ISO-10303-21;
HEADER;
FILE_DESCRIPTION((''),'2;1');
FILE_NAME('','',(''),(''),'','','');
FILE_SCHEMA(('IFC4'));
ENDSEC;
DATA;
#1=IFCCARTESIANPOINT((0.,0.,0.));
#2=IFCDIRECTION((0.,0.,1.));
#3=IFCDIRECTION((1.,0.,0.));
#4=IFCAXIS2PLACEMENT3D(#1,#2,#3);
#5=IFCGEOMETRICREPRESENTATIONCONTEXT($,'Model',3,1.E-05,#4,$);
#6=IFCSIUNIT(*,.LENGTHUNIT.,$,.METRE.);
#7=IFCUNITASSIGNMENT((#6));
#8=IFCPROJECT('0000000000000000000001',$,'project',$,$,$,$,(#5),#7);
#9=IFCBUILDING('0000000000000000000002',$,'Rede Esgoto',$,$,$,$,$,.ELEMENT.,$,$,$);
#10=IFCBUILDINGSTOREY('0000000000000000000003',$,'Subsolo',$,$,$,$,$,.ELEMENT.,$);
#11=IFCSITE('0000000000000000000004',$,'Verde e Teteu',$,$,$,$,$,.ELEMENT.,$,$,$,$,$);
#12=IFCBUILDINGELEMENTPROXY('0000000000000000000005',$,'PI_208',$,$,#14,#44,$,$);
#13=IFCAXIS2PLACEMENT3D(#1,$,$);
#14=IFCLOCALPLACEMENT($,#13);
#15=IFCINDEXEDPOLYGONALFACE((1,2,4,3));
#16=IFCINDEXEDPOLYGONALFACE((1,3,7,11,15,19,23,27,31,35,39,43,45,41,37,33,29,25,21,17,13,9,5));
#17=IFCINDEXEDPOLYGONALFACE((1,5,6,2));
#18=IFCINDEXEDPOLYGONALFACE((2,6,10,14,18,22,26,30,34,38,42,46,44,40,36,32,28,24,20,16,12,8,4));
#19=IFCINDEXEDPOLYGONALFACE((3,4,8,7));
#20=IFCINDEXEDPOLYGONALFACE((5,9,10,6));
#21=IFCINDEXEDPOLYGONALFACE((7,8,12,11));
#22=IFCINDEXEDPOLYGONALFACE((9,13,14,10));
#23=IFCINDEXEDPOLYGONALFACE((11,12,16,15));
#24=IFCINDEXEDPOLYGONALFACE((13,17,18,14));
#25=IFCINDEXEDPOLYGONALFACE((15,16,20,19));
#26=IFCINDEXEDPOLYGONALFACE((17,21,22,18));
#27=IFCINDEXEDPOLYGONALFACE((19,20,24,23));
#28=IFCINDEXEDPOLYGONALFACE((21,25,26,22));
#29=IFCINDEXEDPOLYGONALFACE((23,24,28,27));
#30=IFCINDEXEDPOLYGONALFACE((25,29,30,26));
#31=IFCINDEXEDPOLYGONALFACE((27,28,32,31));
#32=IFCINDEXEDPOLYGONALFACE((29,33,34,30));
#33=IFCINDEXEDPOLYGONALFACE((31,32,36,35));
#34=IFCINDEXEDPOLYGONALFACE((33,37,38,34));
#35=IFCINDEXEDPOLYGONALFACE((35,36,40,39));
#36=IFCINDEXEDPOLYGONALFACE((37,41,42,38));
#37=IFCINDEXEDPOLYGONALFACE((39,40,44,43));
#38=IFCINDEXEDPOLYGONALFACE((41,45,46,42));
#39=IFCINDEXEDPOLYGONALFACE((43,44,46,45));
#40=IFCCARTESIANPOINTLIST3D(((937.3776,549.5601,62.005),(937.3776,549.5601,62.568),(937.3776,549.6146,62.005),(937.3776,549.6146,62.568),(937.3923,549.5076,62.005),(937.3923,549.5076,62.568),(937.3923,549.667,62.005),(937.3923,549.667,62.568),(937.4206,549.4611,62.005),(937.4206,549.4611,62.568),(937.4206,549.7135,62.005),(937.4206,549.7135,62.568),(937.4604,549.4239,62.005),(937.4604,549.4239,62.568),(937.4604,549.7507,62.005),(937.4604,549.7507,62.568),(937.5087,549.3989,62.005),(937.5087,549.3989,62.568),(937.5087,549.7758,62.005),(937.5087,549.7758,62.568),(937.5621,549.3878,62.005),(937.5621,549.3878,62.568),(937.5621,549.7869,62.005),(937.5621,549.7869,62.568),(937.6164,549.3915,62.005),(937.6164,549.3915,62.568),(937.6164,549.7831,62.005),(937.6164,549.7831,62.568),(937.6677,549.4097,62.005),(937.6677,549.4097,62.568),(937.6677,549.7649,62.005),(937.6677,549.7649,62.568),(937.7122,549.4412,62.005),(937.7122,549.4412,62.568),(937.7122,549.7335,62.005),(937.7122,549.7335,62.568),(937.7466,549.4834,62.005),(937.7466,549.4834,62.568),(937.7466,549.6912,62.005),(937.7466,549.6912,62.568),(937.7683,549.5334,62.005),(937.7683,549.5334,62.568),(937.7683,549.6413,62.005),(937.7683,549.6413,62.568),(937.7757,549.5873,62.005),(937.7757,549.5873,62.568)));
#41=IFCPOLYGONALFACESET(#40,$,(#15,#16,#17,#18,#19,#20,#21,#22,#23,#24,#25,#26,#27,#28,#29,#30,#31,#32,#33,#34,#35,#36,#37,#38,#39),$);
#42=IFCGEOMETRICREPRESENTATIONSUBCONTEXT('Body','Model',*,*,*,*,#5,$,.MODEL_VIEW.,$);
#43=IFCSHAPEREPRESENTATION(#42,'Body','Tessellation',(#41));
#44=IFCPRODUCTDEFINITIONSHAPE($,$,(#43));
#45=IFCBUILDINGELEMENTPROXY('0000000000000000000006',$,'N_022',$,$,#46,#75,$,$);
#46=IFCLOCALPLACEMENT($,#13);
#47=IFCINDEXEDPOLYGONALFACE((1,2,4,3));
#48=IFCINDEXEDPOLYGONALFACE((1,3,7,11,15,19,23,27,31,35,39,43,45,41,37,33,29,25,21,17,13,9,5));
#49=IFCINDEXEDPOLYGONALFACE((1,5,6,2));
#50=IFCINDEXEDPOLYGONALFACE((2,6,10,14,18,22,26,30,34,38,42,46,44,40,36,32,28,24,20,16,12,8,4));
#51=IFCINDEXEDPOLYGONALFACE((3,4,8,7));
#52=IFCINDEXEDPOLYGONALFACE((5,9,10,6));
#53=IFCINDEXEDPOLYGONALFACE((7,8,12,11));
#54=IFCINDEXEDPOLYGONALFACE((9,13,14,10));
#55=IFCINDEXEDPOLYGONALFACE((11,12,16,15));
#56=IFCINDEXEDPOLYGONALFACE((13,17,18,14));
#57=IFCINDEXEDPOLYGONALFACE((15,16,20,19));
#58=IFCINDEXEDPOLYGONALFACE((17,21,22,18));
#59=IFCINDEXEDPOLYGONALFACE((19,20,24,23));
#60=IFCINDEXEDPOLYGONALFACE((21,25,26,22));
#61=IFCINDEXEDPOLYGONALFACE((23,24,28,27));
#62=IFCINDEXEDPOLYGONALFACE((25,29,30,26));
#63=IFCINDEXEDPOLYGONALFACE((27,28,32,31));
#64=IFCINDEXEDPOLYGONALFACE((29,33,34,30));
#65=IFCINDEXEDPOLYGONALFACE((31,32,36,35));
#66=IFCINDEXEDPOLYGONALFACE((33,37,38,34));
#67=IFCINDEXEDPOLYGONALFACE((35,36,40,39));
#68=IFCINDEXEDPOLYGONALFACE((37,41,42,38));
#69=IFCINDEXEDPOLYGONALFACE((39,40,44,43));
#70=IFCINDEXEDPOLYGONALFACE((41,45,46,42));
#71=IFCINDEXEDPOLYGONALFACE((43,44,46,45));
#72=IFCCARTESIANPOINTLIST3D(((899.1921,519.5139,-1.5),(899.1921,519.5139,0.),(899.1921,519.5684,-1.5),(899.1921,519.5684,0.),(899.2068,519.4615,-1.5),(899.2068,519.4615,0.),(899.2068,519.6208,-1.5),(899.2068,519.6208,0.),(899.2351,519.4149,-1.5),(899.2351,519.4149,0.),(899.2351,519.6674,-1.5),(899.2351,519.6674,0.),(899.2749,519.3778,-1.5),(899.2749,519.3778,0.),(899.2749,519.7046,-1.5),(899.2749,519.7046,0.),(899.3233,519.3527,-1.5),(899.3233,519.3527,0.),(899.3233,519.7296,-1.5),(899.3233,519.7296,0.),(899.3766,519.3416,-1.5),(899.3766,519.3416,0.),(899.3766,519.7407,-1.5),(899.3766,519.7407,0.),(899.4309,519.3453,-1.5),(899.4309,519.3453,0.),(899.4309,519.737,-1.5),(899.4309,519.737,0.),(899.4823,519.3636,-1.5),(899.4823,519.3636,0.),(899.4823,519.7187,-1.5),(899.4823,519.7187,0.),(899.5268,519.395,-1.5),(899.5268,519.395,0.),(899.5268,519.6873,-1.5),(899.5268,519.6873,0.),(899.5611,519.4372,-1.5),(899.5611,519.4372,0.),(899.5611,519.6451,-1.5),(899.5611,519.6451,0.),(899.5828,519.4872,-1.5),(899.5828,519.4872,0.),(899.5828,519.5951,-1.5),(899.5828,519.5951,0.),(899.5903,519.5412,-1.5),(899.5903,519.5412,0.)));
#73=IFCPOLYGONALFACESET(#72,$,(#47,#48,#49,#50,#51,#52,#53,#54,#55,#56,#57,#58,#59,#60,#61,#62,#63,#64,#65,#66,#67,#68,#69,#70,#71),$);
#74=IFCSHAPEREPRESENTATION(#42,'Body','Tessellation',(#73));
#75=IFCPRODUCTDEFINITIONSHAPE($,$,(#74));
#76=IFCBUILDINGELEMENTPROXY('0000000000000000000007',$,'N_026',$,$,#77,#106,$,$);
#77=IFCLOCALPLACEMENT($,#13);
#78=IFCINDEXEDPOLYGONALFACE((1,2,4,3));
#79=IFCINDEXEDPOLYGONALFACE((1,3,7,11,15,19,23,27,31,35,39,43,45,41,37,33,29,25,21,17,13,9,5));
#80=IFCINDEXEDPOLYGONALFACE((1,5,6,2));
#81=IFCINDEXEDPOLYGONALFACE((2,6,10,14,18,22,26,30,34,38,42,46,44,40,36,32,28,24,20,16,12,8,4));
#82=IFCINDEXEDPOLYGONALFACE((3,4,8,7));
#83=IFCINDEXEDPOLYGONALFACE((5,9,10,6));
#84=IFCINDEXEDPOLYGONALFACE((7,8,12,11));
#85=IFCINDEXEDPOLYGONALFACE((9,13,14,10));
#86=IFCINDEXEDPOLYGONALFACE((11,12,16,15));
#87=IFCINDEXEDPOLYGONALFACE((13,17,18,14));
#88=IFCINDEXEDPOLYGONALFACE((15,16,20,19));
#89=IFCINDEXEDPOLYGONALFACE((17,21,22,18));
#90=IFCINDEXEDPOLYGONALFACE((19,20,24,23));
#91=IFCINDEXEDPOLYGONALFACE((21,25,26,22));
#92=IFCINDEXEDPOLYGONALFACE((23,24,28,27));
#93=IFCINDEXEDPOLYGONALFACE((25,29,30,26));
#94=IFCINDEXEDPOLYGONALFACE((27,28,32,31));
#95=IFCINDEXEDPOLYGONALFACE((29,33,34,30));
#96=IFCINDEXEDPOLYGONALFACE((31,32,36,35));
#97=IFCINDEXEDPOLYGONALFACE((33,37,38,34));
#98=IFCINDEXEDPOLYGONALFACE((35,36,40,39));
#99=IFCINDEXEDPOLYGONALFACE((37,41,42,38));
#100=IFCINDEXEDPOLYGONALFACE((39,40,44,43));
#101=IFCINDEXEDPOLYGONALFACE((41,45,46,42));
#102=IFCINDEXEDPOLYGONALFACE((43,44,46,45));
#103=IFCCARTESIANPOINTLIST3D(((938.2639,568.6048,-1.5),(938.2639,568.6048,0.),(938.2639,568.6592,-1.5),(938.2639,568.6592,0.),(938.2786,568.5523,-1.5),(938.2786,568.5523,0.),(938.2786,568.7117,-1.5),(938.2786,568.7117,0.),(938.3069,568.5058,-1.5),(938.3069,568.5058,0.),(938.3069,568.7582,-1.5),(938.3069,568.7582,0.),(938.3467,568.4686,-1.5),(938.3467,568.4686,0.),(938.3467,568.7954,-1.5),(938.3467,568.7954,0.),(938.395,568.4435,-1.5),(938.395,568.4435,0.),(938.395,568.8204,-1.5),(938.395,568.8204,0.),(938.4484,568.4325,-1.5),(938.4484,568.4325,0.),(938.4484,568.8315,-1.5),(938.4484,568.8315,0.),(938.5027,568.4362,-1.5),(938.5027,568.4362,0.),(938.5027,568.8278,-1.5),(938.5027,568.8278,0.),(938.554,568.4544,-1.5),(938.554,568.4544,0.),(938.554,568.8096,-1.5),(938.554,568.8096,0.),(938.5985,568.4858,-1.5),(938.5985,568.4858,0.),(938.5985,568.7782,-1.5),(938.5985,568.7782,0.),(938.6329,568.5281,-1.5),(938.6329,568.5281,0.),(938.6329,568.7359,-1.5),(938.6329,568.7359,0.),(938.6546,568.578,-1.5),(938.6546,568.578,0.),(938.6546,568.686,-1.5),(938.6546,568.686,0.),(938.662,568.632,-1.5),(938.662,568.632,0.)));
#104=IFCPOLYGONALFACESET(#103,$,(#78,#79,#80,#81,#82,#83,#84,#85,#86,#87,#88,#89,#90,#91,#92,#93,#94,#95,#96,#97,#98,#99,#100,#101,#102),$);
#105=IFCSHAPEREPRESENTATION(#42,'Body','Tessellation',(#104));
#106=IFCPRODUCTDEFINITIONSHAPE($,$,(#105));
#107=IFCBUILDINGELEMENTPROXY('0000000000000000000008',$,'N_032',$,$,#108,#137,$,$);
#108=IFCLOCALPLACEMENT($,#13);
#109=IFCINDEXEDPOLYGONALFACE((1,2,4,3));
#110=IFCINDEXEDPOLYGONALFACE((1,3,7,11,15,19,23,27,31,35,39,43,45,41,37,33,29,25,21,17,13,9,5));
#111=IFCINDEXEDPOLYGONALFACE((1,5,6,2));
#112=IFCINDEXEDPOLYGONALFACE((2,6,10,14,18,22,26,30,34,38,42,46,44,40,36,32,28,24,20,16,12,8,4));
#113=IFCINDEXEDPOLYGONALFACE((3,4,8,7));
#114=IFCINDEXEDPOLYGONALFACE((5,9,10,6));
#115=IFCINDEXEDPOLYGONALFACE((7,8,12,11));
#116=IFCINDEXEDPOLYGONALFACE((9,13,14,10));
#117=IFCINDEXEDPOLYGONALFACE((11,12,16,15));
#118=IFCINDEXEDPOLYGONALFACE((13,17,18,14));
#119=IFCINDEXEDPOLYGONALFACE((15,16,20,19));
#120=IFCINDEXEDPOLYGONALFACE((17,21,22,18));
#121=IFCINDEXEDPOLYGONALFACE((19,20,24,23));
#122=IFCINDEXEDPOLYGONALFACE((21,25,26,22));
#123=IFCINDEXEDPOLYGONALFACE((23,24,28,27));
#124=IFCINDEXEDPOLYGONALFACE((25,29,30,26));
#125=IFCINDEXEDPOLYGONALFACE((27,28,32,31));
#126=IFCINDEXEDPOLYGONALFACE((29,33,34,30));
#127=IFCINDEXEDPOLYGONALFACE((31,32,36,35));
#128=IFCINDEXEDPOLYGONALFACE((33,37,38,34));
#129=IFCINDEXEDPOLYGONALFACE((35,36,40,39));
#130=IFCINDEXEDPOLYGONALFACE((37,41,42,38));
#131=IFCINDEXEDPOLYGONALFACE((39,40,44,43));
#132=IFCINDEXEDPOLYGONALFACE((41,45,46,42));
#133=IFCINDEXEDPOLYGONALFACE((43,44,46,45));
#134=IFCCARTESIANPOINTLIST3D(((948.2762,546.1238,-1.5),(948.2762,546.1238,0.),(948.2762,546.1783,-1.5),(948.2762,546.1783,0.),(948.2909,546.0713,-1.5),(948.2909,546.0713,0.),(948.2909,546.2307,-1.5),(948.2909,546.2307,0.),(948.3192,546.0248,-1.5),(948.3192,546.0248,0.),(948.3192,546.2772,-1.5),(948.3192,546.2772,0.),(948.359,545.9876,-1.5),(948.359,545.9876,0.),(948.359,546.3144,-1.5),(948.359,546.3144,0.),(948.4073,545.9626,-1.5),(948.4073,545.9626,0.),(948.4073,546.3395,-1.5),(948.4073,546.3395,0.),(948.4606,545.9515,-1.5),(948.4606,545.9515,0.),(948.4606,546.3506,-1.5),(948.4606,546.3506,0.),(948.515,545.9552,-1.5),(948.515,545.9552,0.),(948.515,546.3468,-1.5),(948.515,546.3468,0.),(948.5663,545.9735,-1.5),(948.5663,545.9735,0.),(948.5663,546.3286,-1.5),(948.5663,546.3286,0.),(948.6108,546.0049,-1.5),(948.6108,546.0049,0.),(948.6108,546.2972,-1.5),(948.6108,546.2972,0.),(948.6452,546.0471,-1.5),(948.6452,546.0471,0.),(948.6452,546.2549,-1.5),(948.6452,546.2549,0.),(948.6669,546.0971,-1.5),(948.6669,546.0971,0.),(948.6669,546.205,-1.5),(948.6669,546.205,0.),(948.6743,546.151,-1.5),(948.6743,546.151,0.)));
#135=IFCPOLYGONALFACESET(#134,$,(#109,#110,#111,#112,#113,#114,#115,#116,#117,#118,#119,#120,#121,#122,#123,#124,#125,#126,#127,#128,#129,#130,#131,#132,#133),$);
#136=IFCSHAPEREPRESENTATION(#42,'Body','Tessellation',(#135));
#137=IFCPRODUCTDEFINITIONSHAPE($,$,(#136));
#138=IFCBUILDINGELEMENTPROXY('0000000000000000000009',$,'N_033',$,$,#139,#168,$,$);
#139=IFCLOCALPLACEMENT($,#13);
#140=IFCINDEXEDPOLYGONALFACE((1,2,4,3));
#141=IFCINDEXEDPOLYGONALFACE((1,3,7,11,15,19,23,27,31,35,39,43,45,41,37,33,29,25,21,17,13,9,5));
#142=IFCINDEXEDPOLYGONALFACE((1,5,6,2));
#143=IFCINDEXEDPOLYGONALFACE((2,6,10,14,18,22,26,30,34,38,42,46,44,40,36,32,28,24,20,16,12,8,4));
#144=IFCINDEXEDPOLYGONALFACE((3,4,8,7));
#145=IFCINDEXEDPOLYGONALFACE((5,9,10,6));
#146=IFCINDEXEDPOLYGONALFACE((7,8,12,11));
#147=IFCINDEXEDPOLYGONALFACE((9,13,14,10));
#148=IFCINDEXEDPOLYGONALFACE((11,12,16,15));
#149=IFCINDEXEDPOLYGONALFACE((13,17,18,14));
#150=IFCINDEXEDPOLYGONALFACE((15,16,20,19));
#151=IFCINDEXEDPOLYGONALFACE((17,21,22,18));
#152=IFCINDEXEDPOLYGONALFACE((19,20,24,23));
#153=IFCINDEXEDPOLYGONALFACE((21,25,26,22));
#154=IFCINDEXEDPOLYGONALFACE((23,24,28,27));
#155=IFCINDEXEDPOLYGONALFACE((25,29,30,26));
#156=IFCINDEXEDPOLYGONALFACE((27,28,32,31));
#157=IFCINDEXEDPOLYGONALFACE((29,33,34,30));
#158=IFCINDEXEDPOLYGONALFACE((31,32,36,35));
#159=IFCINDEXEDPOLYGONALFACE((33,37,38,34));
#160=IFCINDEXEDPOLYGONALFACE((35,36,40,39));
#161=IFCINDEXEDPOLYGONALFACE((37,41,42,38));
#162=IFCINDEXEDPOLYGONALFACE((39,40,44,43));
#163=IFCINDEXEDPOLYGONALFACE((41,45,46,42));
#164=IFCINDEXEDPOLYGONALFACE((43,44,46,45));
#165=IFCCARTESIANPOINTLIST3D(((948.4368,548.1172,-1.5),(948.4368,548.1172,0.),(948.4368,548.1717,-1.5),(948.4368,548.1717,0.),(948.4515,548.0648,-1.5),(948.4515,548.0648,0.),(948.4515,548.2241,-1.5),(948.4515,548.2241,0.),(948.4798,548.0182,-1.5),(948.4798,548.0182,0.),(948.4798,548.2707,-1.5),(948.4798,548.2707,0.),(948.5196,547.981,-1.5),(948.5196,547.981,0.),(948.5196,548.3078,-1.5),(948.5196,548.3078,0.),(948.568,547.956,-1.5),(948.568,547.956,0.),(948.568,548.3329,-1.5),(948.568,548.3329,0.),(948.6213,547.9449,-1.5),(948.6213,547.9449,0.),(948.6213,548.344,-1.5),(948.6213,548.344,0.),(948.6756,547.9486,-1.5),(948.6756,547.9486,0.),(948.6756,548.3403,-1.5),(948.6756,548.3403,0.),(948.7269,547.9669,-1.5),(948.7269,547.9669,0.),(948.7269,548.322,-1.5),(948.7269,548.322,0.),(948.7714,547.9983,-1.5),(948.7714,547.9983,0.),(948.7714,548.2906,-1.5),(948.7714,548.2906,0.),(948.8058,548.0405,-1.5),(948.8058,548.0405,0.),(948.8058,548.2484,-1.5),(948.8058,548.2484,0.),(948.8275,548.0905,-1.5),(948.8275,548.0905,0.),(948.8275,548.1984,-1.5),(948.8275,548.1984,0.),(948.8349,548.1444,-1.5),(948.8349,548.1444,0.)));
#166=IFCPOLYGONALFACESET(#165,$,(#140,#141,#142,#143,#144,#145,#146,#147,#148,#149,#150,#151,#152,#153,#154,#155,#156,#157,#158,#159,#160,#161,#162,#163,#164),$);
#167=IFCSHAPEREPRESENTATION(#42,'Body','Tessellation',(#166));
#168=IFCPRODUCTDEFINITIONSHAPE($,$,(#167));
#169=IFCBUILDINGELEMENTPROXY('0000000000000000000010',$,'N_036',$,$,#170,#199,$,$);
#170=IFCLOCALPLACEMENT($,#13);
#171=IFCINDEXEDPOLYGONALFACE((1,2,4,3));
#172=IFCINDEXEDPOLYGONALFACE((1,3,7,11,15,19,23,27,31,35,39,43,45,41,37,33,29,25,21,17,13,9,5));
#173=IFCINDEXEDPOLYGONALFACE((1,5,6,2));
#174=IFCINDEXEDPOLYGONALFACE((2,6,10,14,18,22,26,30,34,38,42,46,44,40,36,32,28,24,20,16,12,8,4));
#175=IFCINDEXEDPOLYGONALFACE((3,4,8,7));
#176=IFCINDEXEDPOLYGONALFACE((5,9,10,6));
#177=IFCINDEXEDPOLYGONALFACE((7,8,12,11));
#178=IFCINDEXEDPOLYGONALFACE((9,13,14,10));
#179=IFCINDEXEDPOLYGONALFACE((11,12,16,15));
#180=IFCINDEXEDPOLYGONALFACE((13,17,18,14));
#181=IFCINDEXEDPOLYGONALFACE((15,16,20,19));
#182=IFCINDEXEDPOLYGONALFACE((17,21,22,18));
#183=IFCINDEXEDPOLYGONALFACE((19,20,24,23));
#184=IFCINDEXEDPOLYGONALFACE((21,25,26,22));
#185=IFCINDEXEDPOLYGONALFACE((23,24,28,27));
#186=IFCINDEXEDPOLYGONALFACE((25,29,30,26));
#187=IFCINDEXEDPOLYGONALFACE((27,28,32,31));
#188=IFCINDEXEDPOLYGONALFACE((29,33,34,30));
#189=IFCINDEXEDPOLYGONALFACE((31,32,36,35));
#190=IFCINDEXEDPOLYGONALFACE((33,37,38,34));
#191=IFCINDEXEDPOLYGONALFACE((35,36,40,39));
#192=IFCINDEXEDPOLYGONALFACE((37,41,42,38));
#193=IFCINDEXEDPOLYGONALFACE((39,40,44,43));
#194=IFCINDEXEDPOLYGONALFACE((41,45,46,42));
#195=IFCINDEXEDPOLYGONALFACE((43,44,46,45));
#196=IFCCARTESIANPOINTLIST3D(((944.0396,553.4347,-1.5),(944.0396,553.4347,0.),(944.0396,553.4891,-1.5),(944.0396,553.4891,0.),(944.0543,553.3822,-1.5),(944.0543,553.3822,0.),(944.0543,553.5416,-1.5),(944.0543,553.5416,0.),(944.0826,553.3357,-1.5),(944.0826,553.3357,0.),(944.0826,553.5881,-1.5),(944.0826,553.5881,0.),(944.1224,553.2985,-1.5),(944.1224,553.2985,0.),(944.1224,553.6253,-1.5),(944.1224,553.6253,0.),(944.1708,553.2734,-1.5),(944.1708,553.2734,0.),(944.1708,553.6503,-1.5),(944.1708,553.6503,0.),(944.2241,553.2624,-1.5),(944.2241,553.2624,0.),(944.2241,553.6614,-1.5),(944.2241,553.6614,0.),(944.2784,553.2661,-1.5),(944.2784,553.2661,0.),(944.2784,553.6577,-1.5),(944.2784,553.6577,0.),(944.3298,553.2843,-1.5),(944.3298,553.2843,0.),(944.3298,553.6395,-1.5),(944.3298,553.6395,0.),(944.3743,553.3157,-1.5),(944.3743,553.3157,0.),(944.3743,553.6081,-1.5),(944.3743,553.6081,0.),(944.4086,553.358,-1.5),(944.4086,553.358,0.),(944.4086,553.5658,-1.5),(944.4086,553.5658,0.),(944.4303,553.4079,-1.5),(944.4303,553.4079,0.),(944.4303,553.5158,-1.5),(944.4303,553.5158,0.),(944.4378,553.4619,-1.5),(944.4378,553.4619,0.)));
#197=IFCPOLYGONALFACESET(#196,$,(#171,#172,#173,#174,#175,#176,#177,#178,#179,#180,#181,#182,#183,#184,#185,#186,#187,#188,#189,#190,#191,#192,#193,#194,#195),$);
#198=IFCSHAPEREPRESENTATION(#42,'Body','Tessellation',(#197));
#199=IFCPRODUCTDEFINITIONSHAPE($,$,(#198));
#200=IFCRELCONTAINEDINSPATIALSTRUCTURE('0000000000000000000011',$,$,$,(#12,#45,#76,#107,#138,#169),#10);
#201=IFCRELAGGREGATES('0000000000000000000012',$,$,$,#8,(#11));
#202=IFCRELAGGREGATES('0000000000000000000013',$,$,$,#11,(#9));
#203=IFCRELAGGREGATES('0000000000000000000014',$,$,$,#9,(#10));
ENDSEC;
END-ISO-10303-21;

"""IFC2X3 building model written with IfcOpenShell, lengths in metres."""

from ifc_helpers import new_model, si_unit, frame, origin_with_axes, origin_2d, place, context, subcontext, project, spatial, circle, extrude, element, save


model = new_model("IFC2X3")

# Units and contexts
model_context = context("Model", 3, precision=1e-05, world=origin_with_axes())
body_context = subcontext(model_context, "Body", "Model", "MODEL_VIEW")
ifc_project = project(units=[si_unit("LENGTHUNIT", "METRE")], contexts=[model_context])

# Site, building, storey
site = spatial("IfcSite", under=ifc_project, Name="Verde e Teteu", CompositionType="ELEMENT")
building = spatial("IfcBuilding", under=site, Name="Rede Esgoto", CompositionType="ELEMENT")
storey = spatial("IfcBuildingStorey", under=building, Name="Subsolo", CompositionType="ELEMENT")

# Building element proxies
proxy_1_placement = place(None, frame((937.5757, 549.5873, 62.005), z_axis=(0.0, 0.0, 1.0), x_axis=(1.0, 0.0, 0.0)))
element("IfcBuildingElementProxy", 1, at=proxy_1_placement, inside=storey, Name="PI_208", context=body_context, shape_type="SweptSolid", body=[
    extrude(circle(Radius=0.2, at=origin_2d()), origin_with_axes(), (0.0, 0.0, 1.0), 0.563),
])
for number, where, z_axis, x_axis, name in (
    (2, (899.3903, 519.5412, -1.5), (0.0, 0.0, 1.0), (1.0, 0.0, 0.0), "N_022"),
    (3, (938.462, 568.632, -1.5), (0.0, 0.0, 1.0), (1.0, 0.0, 0.0), "N_026"),
    (4, (948.4743, 546.151, -1.5), (0.0, 0.0, 1.0), (1.0, 0.0, 0.0), "N_032"),
    (5, (948.6349, 548.1444, -1.5), (0.0, 0.0, 1.0), (1.0, 0.0, 0.0), "N_033"),
    (6, (944.2378, 553.4619, -1.5), (0.0, 0.0, 1.0), (1.0, 0.0, 0.0), "N_036"),
):
    element("IfcBuildingElementProxy", number, at=place(None, frame(where, z_axis=z_axis, x_axis=x_axis)), inside=storey, Name=name, context=body_context, shape_type="SweptSolid", body=[
        extrude(circle(Radius=0.2, at=origin_2d()), origin_with_axes(), (0.0, 0.0, 1.0), 1.5),
    ])

save(model, "model.ifc")
